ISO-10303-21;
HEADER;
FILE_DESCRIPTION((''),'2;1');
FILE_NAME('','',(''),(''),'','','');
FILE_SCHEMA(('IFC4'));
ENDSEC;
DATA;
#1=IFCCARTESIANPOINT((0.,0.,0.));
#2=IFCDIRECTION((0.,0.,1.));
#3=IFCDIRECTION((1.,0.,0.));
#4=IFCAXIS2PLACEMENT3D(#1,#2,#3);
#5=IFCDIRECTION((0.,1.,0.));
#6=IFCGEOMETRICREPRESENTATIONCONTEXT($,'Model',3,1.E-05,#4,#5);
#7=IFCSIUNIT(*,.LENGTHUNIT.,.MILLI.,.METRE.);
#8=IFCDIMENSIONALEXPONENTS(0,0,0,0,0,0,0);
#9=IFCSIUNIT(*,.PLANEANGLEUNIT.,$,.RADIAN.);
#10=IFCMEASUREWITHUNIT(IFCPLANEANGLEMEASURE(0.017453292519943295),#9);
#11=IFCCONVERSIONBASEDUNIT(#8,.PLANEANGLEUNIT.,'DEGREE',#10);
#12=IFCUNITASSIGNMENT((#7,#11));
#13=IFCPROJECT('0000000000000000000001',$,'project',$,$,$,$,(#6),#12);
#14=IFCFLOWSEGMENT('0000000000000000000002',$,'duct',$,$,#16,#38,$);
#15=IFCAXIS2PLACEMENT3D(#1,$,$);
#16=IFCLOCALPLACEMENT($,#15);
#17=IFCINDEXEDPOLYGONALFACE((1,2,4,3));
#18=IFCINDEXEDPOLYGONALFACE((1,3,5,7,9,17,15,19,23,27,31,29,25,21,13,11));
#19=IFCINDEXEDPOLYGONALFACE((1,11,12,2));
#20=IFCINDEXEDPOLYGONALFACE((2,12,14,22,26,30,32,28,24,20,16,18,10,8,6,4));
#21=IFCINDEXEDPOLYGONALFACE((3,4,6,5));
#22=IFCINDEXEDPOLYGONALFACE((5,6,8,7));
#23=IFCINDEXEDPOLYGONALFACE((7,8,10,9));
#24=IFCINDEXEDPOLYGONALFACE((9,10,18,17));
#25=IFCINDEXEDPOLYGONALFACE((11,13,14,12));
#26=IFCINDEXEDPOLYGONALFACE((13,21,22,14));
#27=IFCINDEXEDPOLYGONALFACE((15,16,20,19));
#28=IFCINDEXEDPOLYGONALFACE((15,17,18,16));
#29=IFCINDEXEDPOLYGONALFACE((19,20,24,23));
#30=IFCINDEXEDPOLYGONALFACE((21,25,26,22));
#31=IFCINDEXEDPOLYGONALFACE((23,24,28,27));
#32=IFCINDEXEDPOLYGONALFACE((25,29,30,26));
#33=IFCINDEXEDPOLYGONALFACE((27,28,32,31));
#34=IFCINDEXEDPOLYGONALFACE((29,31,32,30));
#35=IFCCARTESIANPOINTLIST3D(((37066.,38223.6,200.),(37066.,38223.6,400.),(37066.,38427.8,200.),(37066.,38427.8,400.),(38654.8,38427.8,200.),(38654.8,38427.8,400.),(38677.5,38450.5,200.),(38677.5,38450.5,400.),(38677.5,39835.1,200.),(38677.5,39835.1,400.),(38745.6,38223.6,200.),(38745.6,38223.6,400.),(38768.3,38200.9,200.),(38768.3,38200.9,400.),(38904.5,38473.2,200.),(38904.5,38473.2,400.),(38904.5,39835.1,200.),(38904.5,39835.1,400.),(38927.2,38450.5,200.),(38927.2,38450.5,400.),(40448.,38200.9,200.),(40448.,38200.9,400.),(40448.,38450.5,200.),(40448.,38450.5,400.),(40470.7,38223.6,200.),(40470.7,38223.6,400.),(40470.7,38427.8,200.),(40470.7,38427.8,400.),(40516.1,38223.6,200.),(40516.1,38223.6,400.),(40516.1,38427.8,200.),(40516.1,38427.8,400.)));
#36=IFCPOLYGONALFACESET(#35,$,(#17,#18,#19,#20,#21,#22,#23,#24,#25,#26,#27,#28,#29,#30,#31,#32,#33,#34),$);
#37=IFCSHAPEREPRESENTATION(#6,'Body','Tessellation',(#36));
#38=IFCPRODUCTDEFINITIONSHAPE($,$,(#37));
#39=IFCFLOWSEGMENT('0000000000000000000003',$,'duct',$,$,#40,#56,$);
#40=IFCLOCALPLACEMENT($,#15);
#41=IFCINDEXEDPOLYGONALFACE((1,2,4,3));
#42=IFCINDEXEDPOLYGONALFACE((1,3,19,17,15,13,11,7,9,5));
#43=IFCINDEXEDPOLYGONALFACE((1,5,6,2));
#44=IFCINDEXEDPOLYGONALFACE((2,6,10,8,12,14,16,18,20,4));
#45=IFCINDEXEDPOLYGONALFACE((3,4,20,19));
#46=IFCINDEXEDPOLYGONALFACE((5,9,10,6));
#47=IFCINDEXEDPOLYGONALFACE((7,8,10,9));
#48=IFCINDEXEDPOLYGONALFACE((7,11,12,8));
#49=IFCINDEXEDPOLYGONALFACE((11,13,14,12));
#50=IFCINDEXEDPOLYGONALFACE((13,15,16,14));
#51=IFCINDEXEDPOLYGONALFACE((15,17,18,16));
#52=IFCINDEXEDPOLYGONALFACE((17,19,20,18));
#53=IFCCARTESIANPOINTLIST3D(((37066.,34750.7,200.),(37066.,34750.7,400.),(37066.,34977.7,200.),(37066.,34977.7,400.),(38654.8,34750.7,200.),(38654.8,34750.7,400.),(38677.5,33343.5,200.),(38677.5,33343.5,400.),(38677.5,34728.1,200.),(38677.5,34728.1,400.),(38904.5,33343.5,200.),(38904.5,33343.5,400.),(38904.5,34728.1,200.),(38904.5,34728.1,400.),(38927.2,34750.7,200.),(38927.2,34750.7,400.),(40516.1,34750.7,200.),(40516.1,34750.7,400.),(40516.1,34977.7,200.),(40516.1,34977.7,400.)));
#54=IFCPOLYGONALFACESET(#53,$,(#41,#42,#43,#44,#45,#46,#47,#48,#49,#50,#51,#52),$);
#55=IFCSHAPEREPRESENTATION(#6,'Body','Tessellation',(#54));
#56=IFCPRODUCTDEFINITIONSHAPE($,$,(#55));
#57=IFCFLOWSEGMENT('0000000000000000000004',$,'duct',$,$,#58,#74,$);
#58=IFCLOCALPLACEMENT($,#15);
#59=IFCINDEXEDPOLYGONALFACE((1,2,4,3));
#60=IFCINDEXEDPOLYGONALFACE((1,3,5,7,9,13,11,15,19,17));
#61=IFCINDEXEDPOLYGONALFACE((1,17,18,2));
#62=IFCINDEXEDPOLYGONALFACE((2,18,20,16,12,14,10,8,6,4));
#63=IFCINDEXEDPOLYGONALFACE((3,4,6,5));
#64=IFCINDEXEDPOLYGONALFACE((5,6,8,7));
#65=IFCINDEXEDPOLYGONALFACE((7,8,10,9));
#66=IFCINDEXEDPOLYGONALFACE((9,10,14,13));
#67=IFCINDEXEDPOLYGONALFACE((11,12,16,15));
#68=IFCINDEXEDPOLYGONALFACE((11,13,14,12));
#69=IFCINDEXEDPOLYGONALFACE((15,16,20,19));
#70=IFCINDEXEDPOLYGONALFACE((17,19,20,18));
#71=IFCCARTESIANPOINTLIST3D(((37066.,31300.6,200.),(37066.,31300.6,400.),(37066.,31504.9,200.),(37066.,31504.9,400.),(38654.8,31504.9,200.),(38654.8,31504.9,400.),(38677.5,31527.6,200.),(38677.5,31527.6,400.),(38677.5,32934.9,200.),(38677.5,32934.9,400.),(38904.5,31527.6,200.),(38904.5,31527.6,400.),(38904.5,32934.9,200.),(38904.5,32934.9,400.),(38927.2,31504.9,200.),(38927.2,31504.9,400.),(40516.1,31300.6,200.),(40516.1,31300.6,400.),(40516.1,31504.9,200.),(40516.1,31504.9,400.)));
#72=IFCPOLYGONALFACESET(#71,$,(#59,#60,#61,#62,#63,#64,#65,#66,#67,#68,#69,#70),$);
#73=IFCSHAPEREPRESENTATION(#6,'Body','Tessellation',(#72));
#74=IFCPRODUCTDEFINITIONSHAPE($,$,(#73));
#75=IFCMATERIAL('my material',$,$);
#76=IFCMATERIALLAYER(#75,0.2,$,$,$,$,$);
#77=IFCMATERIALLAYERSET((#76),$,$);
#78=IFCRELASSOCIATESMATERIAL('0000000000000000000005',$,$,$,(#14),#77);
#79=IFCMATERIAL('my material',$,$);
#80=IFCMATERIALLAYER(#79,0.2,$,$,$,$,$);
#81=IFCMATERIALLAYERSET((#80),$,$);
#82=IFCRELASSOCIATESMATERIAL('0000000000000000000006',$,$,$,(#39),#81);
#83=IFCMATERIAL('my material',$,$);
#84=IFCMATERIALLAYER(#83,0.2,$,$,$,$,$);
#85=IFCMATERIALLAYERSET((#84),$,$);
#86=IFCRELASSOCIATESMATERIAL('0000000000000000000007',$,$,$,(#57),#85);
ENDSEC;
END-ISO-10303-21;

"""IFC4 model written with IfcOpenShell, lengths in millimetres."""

from ifc_helpers import new_model, entity, si_unit, converted_unit, direction, frame, origin_with_axes, place, context, project, polyline, outline, extrude, material, layer, layer_set, layer_usage, element, save


model = new_model("IFC4")

# Units and contexts
model_context = context("Model", 3, precision=1e-05, world=origin_with_axes(), true_north=direction((0.0, 1.0, 0.0)))
ifc_project = project(units=[si_unit("LENGTHUNIT", "METRE", prefix="MILLI"), converted_unit("PLANEANGLEUNIT", "DEGREE", entity("IfcPlaneAngleMeasure", 0.017453292519943295), si_unit("PLANEANGLEUNIT", "RADIAN"), dimensions=[0, 0, 0, 0, 0, 0, 0])], contexts=[model_context])

# Flow segments
ifc_material_1 = material(Name="my material")
ifc_layer_1 = layer(ifc_material_1, 0.2)
ifc_layer_set_1 = layer_set([ifc_layer_1])
ifc_layer_usage_1 = layer_usage(ifc_layer_set_1, "AXIS2", "POSITIVE", -0.1)
flow_segment_1_placement = place(None, origin_with_axes())
element("IfcFlowSegment", 1, at=flow_segment_1_placement, material=ifc_layer_usage_1, Name="duct", context=model_context, shape_type="SweptSolid", body=[
    extrude(outline(polyline([(37066.0, 38223.6), (38745.6, 38223.6), (38768.3, 38200.9), (40448.0, 38200.9), (40470.7, 38223.6), (40516.1, 38223.6), (40516.1, 38427.8), (40470.7, 38427.8), (40448.0, 38450.5), (38927.2, 38450.5), (38904.5, 38473.2), (38904.5, 39835.1), (38677.5, 39835.1), (38677.5, 38450.5), (38654.8, 38427.8), (37066.0, 38427.8), (37066.0, 38223.6)])), frame((0.0, 0.0, 200.0), z_axis=(0.0, 0.0, 1.0), x_axis=(1.0, 0.0, 0.0)), (0.0, 0.0, 1.0), 200.0),
])
ifc_material_2 = material(Name="my material")
ifc_layer_2 = layer(ifc_material_2, 0.2)
ifc_layer_set_2 = layer_set([ifc_layer_2])
ifc_layer_usage_2 = layer_usage(ifc_layer_set_2, "AXIS2", "POSITIVE", -0.1)
flow_segment_2_placement = place(None, origin_with_axes())
element("IfcFlowSegment", 2, at=flow_segment_2_placement, material=ifc_layer_usage_2, Name="duct", context=model_context, shape_type="SweptSolid", body=[
    extrude(outline(polyline([(37066.0, 34750.7), (38654.8, 34750.7), (38677.5, 34728.1), (38677.5, 33343.5), (38904.5, 33343.5), (38904.5, 34728.1), (38927.2, 34750.7), (40516.1, 34750.7), (40516.1, 34977.7), (37066.0, 34977.7), (37066.0, 34750.7)])), frame((0.0, 0.0, 200.0), z_axis=(0.0, 0.0, 1.0), x_axis=(1.0, 0.0, 0.0)), (0.0, 0.0, 1.0), 200.0),
])
ifc_material_3 = material(Name="my material")
ifc_layer_3 = layer(ifc_material_3, 0.2)
ifc_layer_set_3 = layer_set([ifc_layer_3])
ifc_layer_usage_3 = layer_usage(ifc_layer_set_3, "AXIS2", "POSITIVE", -0.1)
flow_segment_3_placement = place(None, origin_with_axes())
element("IfcFlowSegment", 3, at=flow_segment_3_placement, material=ifc_layer_usage_3, Name="duct", context=model_context, shape_type="SweptSolid", body=[
    extrude(outline(polyline([(37066.0, 31300.6), (40516.1, 31300.6), (40516.1, 31504.9), (38927.2, 31504.9), (38904.5, 31527.6), (38904.5, 32934.9), (38677.5, 32934.9), (38677.5, 31527.6), (38654.8, 31504.9), (37066.0, 31504.9), (37066.0, 31300.6)])), frame((0.0, 0.0, 200.0), z_axis=(0.0, 0.0, 1.0), x_axis=(1.0, 0.0, 0.0)), (0.0, 0.0, 1.0), 200.0),
])

save(model, "model.ifc")
